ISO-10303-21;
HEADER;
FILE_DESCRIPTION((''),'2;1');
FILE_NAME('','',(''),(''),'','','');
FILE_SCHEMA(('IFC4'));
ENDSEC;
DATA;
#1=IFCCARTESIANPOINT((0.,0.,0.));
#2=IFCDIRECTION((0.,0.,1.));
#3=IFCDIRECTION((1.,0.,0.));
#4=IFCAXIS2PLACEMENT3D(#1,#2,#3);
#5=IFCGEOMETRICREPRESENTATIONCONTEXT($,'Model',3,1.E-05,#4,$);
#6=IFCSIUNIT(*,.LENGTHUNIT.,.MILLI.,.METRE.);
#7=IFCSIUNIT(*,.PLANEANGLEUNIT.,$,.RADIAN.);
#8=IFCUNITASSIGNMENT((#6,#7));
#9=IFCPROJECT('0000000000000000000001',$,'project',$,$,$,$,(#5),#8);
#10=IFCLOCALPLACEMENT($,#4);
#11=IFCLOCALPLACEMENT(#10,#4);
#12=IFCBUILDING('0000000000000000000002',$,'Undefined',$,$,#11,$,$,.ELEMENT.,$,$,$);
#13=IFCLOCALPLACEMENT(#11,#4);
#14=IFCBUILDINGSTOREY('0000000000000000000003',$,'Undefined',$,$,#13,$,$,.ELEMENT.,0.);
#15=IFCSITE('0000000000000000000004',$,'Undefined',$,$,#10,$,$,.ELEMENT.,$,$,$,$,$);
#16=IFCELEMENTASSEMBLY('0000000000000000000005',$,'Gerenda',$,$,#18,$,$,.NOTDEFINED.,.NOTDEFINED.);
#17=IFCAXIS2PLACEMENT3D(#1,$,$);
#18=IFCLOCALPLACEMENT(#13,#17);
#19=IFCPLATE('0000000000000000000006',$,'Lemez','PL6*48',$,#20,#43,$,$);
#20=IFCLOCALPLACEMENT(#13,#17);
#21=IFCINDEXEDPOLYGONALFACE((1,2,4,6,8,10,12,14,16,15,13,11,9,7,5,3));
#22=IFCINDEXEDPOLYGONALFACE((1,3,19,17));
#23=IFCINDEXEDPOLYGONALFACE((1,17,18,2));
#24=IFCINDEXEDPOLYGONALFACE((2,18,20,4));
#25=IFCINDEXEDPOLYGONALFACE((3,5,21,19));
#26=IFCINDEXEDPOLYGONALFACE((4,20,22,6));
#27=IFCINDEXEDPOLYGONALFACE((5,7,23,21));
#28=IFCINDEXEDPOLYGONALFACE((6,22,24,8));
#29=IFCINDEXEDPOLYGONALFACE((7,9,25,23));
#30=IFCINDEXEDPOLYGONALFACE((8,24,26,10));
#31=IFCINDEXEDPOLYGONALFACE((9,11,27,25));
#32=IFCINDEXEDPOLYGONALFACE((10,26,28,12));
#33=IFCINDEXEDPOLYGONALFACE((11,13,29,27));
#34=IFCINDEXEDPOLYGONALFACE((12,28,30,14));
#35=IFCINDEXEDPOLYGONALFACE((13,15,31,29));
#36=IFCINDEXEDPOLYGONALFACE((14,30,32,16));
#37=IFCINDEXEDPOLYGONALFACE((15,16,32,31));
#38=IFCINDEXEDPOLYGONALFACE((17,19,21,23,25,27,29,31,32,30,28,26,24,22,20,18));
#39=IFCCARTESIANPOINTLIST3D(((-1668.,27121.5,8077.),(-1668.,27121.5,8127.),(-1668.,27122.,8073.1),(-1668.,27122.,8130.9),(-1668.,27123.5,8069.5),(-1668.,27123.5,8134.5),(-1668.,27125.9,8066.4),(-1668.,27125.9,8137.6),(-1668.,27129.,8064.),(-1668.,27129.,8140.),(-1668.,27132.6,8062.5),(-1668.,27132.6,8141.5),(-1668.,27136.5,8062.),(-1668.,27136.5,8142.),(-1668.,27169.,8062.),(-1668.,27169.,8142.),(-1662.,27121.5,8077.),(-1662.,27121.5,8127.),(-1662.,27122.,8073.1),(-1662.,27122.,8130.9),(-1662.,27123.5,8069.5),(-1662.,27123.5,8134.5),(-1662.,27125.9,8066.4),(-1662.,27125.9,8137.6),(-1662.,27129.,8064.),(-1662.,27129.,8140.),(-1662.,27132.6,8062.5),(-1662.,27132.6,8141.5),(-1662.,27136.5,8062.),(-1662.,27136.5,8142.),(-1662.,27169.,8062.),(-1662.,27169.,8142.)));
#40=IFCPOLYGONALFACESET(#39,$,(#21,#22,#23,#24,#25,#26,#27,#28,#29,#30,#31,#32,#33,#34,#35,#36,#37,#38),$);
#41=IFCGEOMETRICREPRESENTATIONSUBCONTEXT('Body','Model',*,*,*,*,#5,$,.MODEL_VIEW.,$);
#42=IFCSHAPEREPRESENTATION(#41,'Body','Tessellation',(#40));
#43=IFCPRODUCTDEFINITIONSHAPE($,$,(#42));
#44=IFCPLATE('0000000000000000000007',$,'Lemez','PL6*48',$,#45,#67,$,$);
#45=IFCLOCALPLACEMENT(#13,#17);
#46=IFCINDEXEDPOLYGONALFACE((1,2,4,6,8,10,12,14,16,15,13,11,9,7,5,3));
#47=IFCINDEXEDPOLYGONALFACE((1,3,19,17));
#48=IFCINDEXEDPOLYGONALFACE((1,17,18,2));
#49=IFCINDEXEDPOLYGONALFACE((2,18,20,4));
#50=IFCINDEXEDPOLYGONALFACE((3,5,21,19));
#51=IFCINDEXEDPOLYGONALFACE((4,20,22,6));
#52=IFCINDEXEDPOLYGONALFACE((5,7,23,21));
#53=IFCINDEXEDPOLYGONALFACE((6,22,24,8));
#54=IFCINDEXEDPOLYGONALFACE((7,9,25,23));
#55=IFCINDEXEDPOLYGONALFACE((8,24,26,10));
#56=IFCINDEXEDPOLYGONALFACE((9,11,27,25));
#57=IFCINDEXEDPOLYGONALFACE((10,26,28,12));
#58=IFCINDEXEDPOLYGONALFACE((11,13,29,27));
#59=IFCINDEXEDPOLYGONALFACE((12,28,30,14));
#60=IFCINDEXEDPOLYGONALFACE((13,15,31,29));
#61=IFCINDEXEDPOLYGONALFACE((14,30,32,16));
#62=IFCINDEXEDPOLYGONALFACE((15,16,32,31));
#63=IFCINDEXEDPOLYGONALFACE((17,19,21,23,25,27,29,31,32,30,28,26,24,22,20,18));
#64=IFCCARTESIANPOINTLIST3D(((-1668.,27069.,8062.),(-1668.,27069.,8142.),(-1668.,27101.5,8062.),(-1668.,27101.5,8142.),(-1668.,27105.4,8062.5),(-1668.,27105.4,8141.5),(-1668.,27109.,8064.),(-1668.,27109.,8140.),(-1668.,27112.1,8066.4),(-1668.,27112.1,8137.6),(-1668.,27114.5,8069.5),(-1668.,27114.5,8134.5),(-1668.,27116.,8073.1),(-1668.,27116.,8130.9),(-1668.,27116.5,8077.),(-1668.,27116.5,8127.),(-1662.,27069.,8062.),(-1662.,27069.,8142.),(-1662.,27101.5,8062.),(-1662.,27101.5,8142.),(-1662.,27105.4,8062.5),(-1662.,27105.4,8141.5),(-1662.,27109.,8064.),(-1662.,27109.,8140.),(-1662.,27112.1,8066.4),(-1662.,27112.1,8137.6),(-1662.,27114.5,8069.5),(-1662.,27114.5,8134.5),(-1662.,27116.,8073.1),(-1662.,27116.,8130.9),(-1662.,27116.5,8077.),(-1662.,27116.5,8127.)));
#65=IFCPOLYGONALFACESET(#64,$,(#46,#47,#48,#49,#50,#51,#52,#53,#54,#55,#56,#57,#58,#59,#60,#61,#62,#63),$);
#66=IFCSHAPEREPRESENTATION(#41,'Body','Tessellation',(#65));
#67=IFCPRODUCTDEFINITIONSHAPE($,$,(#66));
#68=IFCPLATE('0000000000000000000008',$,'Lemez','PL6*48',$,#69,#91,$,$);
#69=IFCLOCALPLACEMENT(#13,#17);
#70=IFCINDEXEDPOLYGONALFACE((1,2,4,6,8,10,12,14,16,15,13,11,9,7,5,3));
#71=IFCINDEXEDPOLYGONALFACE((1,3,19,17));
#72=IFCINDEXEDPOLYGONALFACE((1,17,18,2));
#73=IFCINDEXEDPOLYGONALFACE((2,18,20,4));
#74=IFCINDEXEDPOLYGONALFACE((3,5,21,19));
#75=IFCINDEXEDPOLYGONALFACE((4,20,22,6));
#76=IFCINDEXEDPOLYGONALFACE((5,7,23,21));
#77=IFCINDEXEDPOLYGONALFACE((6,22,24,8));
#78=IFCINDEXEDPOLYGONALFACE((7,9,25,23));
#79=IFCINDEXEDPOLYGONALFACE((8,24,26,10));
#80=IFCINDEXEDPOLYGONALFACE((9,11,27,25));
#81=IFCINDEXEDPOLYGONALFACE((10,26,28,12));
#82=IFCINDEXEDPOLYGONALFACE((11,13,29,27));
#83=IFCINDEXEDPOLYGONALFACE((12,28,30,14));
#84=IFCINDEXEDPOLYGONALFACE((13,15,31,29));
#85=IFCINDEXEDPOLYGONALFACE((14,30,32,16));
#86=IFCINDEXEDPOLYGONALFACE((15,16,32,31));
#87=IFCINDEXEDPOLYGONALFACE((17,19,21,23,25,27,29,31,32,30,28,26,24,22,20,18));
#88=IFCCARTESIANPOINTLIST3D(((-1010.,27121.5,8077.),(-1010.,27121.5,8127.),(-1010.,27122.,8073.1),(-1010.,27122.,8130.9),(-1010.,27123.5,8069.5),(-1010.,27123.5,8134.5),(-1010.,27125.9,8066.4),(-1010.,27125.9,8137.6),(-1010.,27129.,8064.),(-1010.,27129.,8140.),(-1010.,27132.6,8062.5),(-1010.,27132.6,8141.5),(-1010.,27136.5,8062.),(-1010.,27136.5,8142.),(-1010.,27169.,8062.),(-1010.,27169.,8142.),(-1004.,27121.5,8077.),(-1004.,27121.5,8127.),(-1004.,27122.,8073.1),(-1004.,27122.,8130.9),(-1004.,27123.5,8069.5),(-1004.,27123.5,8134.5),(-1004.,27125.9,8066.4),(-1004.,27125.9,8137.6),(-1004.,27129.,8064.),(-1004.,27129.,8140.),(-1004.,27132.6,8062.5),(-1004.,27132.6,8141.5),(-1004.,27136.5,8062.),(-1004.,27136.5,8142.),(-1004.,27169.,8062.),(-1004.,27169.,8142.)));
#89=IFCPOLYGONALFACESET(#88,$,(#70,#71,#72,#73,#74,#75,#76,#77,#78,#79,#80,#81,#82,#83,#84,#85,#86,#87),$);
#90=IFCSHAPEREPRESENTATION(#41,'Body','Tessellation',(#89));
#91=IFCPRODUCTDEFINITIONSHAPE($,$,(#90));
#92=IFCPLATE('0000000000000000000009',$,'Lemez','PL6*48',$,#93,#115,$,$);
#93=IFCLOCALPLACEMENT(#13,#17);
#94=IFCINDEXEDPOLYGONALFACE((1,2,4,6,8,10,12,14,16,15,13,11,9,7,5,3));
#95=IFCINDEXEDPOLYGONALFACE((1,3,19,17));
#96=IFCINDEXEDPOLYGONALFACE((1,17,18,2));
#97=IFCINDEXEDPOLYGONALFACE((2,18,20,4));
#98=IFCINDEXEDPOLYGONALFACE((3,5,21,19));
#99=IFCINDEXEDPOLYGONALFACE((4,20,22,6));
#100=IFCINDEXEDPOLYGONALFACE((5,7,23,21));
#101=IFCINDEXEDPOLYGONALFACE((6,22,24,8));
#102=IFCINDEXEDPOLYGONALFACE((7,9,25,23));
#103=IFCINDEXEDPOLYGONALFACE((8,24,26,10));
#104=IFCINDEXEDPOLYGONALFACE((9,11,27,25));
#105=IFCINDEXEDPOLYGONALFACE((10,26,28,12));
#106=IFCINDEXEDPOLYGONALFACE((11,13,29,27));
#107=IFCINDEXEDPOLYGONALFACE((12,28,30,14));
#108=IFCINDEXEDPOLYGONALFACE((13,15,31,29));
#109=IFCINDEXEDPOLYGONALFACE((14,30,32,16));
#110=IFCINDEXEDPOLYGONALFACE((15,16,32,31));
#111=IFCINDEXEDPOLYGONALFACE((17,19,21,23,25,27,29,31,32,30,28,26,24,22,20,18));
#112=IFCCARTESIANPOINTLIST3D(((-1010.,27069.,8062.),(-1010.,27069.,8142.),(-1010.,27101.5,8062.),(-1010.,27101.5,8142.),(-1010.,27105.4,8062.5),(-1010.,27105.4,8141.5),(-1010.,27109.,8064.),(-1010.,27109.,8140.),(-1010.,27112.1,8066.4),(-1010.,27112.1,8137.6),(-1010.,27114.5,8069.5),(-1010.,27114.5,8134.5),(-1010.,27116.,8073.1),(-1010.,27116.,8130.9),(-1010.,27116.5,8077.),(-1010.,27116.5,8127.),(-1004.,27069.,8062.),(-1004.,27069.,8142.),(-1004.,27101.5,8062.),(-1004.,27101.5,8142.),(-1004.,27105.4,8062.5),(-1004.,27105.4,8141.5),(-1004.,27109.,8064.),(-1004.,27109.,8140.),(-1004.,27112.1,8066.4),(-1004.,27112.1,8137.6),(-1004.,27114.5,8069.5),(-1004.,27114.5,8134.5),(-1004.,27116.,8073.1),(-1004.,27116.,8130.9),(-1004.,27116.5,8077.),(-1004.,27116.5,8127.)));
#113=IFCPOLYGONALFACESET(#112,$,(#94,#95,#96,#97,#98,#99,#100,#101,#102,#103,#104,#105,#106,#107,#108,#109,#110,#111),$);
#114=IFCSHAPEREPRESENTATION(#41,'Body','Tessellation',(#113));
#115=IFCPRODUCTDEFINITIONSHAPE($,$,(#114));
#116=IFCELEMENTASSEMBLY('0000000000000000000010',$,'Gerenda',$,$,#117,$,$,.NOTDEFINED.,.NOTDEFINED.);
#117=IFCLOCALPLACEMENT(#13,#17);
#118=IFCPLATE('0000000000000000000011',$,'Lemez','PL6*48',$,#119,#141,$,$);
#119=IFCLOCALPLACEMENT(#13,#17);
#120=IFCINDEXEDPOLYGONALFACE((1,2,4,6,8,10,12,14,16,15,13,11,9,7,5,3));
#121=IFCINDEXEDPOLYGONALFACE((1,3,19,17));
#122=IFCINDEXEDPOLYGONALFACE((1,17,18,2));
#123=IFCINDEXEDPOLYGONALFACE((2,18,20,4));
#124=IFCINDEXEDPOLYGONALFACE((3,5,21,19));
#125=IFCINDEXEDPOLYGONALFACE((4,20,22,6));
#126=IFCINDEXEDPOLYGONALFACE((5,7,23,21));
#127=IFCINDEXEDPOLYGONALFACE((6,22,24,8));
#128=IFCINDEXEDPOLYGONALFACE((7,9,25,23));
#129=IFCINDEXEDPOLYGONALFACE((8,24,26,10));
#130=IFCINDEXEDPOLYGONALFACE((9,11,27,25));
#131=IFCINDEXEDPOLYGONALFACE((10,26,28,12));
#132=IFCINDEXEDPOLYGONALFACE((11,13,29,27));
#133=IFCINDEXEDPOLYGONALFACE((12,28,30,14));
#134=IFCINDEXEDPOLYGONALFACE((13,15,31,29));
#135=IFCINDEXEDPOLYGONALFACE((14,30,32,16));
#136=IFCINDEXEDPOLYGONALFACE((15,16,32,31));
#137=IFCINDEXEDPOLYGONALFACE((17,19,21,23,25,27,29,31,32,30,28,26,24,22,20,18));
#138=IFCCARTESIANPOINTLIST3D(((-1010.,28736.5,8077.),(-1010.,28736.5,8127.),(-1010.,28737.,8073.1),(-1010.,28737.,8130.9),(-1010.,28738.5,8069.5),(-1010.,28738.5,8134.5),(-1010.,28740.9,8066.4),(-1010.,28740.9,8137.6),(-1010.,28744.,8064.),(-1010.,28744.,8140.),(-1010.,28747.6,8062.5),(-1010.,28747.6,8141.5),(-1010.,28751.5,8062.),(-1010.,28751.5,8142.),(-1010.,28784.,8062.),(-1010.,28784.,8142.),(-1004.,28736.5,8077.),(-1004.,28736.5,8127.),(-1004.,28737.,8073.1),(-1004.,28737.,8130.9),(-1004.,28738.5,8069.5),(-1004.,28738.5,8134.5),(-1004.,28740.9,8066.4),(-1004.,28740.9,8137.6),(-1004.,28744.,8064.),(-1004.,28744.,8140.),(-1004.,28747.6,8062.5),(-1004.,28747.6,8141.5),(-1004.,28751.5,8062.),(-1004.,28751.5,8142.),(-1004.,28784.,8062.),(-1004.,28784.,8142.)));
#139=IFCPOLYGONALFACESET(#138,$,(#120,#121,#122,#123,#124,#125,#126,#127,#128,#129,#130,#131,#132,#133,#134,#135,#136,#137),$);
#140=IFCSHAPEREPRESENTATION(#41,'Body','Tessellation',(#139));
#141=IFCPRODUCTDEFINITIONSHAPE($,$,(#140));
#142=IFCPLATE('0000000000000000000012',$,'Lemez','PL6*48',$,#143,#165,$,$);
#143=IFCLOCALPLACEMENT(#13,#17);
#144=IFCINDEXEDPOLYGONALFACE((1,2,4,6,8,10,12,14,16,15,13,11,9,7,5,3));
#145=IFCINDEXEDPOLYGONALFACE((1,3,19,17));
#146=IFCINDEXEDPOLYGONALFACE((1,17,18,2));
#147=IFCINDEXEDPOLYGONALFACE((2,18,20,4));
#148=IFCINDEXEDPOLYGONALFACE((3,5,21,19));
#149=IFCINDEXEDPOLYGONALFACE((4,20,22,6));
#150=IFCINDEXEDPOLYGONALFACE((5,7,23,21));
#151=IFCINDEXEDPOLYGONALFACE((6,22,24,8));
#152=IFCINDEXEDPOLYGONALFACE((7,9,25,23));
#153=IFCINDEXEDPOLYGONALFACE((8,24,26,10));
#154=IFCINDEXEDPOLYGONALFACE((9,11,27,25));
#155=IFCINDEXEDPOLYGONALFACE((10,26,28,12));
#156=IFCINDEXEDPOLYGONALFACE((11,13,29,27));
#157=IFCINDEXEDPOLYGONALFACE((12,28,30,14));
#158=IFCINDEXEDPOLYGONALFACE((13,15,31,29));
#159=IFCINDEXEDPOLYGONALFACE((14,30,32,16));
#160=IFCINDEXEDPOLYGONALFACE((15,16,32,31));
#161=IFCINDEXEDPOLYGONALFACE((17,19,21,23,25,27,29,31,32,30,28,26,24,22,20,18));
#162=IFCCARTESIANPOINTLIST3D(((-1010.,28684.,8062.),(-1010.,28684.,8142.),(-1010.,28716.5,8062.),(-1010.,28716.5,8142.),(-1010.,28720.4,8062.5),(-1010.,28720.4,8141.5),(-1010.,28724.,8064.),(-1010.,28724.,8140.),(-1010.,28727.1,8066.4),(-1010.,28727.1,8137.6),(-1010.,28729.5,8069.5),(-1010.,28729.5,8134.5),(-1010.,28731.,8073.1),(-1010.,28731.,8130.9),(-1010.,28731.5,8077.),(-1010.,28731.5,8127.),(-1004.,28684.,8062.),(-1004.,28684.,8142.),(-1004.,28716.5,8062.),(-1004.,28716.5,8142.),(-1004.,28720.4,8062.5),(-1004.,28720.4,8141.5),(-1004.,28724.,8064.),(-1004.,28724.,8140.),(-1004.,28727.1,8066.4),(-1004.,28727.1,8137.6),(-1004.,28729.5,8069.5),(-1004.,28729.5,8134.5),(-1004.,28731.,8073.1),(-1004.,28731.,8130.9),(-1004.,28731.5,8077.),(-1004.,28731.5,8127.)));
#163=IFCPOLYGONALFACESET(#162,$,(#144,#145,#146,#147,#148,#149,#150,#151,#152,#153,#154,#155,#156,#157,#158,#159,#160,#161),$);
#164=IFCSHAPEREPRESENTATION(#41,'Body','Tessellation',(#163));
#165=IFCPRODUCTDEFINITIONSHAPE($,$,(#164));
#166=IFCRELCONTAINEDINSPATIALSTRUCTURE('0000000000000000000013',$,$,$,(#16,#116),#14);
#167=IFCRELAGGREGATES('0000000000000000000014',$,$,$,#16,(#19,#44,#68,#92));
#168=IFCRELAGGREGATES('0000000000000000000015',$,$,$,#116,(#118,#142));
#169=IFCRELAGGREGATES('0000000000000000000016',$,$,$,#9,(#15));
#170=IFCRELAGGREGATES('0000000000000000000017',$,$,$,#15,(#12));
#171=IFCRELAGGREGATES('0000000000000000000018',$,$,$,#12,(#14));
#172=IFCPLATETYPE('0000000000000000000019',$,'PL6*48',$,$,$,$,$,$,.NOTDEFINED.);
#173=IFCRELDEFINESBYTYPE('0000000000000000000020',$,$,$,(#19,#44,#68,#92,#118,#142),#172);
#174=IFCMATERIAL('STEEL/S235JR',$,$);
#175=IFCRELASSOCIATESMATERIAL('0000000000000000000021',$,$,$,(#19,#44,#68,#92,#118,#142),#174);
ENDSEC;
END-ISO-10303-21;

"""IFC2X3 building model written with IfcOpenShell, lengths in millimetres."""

from ifc_helpers import new_model, si_unit, frame, frame_2d, origin_with_axes, place, context, subcontext, project, spatial, polyline, circle_curve, parameter, trimmed, segment, composite_curve, outline, extrude, material, type_object, element, aggregate, save


model = new_model("IFC2X3")

# Units and contexts
model_context = context("Model", 3, precision=1e-05, world=origin_with_axes())
body_context = subcontext(model_context, "Body", "Model", "MODEL_VIEW")
ifc_project = project(units=[si_unit("LENGTHUNIT", "METRE", prefix="MILLI"), si_unit("PLANEANGLEUNIT", "RADIAN")], contexts=[model_context])

# Site, building, storey
site_placement = place(None, origin_with_axes())
site = spatial("IfcSite", under=ifc_project, at=site_placement, Name="Undefined", CompositionType="ELEMENT")
building_placement = place(site_placement, origin_with_axes())
building = spatial("IfcBuilding", under=site, at=building_placement, Name="Undefined", CompositionType="ELEMENT")
storey_placement = place(building_placement, origin_with_axes())
storey = spatial("IfcBuildingStorey", under=building, at=storey_placement, Name="Undefined", CompositionType="ELEMENT", Elevation=0.0)

# Element assemblies, plates
assembly_1_placement = place(storey_placement, origin_with_axes())
assembly_1 = element("IfcElementAssembly", 1, at=assembly_1_placement, inside=storey, Name="Gerenda", AssemblyPlace="NOTDEFINED", PredefinedType="NOTDEFINED")
ifc_material = material(Name="STEEL/S235JR")
plate_type_1 = type_object("IfcPlateType", Name="PL6*48", PredefinedType="NOTDEFINED")
plate_1_placement = place(assembly_1_placement, frame((-1665.0, 27121.5, 8062.0), z_axis=(1.0, -0.000003, 0.0), x_axis=(0.000003, 1.0, 0.0)))
plate_1 = element("IfcPlate", 2, at=plate_1_placement, type_object=plate_type_1, material=ifc_material, Name="Lemez", Description="PL6*48", context=body_context, shape_type="SweptSolid", body=[
    extrude(outline(composite_curve([segment(trimmed(circle_curve(frame_2d((15.0, 15.0), x_axis=(-1.0, 0.0)), 15.0), [parameter(0.0)], [parameter(1.570796)], True, "PARAMETER"), True, "CONTINUOUS"), segment(polyline([(15.0, 0.0), (47.5, 0.0), (47.5, 80.0), (15.0, 80.0)]), True, "CONTINUOUS"), segment(trimmed(circle_curve(frame_2d((15.0, 65.0), x_axis=(0.0, 1.0)), 15.0), [parameter(0.0)], [parameter(1.570796)], True, "PARAMETER"), True, "CONTINUOUS"), segment(polyline([(0.0, 65.0), (0.0, 15.0)]), True, "CONTINUOUS")], self_intersect=True)), frame((0.0, 0.0, -3.0), z_axis=(0.0, 0.0, 1.0), x_axis=(1.0, 0.0, 0.0)), (0.0, 0.0, 1.0), 6.0),
])
plate_2_placement = place(assembly_1_placement, frame((-1665.0, 27116.5, 8062.0), z_axis=(-1.0, 0.000003, 0.0), x_axis=(-0.000003, -1.0, 0.0)))
plate_2 = element("IfcPlate", 3, at=plate_2_placement, type_object=plate_type_1, material=ifc_material, Name="Lemez", Description="PL6*48", context=body_context, shape_type="SweptSolid", body=[
    extrude(outline(composite_curve([segment(trimmed(circle_curve(frame_2d((15.0, 15.0), x_axis=(-1.0, 0.0)), 15.0), [parameter(0.0)], [parameter(1.570796)], True, "PARAMETER"), True, "CONTINUOUS"), segment(polyline([(15.0, 0.0), (47.5, 0.0), (47.5, 80.0), (15.0, 80.0)]), True, "CONTINUOUS"), segment(trimmed(circle_curve(frame_2d((15.0, 65.0), x_axis=(0.0, 1.0)), 15.0), [parameter(0.0)], [parameter(1.570796)], True, "PARAMETER"), True, "CONTINUOUS"), segment(polyline([(0.0, 65.0), (0.0, 15.0)]), True, "CONTINUOUS")], self_intersect=True)), frame((0.0, 0.0, -3.0), z_axis=(0.0, 0.0, 1.0), x_axis=(1.0, 0.0, 0.0)), (0.0, 0.0, 1.0), 6.0),
])
plate_3_placement = place(assembly_1_placement, frame((-1007.0, 27121.5, 8062.0), z_axis=(1.0, -0.000003, 0.0), x_axis=(0.000003, 1.0, 0.0)))
plate_3 = element("IfcPlate", 4, at=plate_3_placement, type_object=plate_type_1, material=ifc_material, Name="Lemez", Description="PL6*48", context=body_context, shape_type="SweptSolid", body=[
    extrude(outline(composite_curve([segment(trimmed(circle_curve(frame_2d((15.0, 15.0), x_axis=(-1.0, 0.0)), 15.0), [parameter(0.0)], [parameter(1.570796)], True, "PARAMETER"), True, "CONTINUOUS"), segment(polyline([(15.0, 0.0), (47.5, 0.0), (47.5, 80.0), (15.0, 80.0)]), True, "CONTINUOUS"), segment(trimmed(circle_curve(frame_2d((15.0, 65.0), x_axis=(0.0, 1.0)), 15.0), [parameter(0.0)], [parameter(1.570796)], True, "PARAMETER"), True, "CONTINUOUS"), segment(polyline([(0.0, 65.0), (0.0, 15.0)]), True, "CONTINUOUS")], self_intersect=True)), frame((0.0, 0.0, -3.0), z_axis=(0.0, 0.0, 1.0), x_axis=(1.0, 0.0, 0.0)), (0.0, 0.0, 1.0), 6.0),
])
plate_4_placement = place(assembly_1_placement, frame((-1007.0, 27116.5, 8062.0), z_axis=(-1.0, 0.000003, 0.0), x_axis=(-0.000003, -1.0, 0.0)))
plate_4 = element("IfcPlate", 5, at=plate_4_placement, type_object=plate_type_1, material=ifc_material, Name="Lemez", Description="PL6*48", context=body_context, shape_type="SweptSolid", body=[
    extrude(outline(composite_curve([segment(trimmed(circle_curve(frame_2d((15.0, 15.0), x_axis=(-1.0, 0.0)), 15.0), [parameter(0.0)], [parameter(1.570796)], True, "PARAMETER"), True, "CONTINUOUS"), segment(polyline([(15.0, 0.0), (47.5, 0.0), (47.5, 80.0), (15.0, 80.0)]), True, "CONTINUOUS"), segment(trimmed(circle_curve(frame_2d((15.0, 65.0), x_axis=(0.0, 1.0)), 15.0), [parameter(0.0)], [parameter(1.570796)], True, "PARAMETER"), True, "CONTINUOUS"), segment(polyline([(0.0, 65.0), (0.0, 15.0)]), True, "CONTINUOUS")], self_intersect=True)), frame((0.0, 0.0, -3.0), z_axis=(0.0, 0.0, 1.0), x_axis=(1.0, 0.0, 0.0)), (0.0, 0.0, 1.0), 6.0),
])
assembly_2_placement = place(storey_placement, origin_with_axes())
assembly_2 = element("IfcElementAssembly", 6, at=assembly_2_placement, inside=storey, Name="Gerenda", AssemblyPlace="NOTDEFINED", PredefinedType="NOTDEFINED")
plate_5_placement = place(assembly_2_placement, frame((-1007.0, 28736.5, 8062.0), z_axis=(1.0, -0.000003, 0.0), x_axis=(0.000003, 1.0, 0.0)))
plate_5 = element("IfcPlate", 7, at=plate_5_placement, type_object=plate_type_1, material=ifc_material, Name="Lemez", Description="PL6*48", context=body_context, shape_type="SweptSolid", body=[
    extrude(outline(composite_curve([segment(trimmed(circle_curve(frame_2d((15.0, 15.0), x_axis=(-1.0, 0.0)), 15.0), [parameter(0.0)], [parameter(1.570796)], True, "PARAMETER"), True, "CONTINUOUS"), segment(polyline([(15.0, 0.0), (47.5, 0.0), (47.5, 80.0), (15.0, 80.0)]), True, "CONTINUOUS"), segment(trimmed(circle_curve(frame_2d((15.0, 65.0), x_axis=(0.0, 1.0)), 15.0), [parameter(0.0)], [parameter(1.570796)], True, "PARAMETER"), True, "CONTINUOUS"), segment(polyline([(0.0, 65.0), (0.0, 15.0)]), True, "CONTINUOUS")], self_intersect=True)), frame((0.0, 0.0, -3.0), z_axis=(0.0, 0.0, 1.0), x_axis=(1.0, 0.0, 0.0)), (0.0, 0.0, 1.0), 6.0),
])
plate_6_placement = place(assembly_2_placement, frame((-1007.0, 28731.5, 8062.0), z_axis=(-1.0, 0.000003, 0.0), x_axis=(-0.000003, -1.0, 0.0)))
plate_6 = element("IfcPlate", 8, at=plate_6_placement, type_object=plate_type_1, material=ifc_material, Name="Lemez", Description="PL6*48", context=body_context, shape_type="SweptSolid", body=[
    extrude(outline(composite_curve([segment(trimmed(circle_curve(frame_2d((15.0, 15.0), x_axis=(-1.0, 0.0)), 15.0), [parameter(0.0)], [parameter(1.570796)], True, "PARAMETER"), True, "CONTINUOUS"), segment(polyline([(15.0, 0.0), (47.5, 0.0), (47.5, 80.0), (15.0, 80.0)]), True, "CONTINUOUS"), segment(trimmed(circle_curve(frame_2d((15.0, 65.0), x_axis=(0.0, 1.0)), 15.0), [parameter(0.0)], [parameter(1.570796)], True, "PARAMETER"), True, "CONTINUOUS"), segment(polyline([(0.0, 65.0), (0.0, 15.0)]), True, "CONTINUOUS")], self_intersect=True)), frame((0.0, 0.0, -3.0), z_axis=(0.0, 0.0, 1.0), x_axis=(1.0, 0.0, 0.0)), (0.0, 0.0, 1.0), 6.0),
])

aggregate(assembly_1, [plate_1, plate_2, plate_3, plate_4])
aggregate(assembly_2, [plate_5, plate_6])

save(model, "model.ifc")
